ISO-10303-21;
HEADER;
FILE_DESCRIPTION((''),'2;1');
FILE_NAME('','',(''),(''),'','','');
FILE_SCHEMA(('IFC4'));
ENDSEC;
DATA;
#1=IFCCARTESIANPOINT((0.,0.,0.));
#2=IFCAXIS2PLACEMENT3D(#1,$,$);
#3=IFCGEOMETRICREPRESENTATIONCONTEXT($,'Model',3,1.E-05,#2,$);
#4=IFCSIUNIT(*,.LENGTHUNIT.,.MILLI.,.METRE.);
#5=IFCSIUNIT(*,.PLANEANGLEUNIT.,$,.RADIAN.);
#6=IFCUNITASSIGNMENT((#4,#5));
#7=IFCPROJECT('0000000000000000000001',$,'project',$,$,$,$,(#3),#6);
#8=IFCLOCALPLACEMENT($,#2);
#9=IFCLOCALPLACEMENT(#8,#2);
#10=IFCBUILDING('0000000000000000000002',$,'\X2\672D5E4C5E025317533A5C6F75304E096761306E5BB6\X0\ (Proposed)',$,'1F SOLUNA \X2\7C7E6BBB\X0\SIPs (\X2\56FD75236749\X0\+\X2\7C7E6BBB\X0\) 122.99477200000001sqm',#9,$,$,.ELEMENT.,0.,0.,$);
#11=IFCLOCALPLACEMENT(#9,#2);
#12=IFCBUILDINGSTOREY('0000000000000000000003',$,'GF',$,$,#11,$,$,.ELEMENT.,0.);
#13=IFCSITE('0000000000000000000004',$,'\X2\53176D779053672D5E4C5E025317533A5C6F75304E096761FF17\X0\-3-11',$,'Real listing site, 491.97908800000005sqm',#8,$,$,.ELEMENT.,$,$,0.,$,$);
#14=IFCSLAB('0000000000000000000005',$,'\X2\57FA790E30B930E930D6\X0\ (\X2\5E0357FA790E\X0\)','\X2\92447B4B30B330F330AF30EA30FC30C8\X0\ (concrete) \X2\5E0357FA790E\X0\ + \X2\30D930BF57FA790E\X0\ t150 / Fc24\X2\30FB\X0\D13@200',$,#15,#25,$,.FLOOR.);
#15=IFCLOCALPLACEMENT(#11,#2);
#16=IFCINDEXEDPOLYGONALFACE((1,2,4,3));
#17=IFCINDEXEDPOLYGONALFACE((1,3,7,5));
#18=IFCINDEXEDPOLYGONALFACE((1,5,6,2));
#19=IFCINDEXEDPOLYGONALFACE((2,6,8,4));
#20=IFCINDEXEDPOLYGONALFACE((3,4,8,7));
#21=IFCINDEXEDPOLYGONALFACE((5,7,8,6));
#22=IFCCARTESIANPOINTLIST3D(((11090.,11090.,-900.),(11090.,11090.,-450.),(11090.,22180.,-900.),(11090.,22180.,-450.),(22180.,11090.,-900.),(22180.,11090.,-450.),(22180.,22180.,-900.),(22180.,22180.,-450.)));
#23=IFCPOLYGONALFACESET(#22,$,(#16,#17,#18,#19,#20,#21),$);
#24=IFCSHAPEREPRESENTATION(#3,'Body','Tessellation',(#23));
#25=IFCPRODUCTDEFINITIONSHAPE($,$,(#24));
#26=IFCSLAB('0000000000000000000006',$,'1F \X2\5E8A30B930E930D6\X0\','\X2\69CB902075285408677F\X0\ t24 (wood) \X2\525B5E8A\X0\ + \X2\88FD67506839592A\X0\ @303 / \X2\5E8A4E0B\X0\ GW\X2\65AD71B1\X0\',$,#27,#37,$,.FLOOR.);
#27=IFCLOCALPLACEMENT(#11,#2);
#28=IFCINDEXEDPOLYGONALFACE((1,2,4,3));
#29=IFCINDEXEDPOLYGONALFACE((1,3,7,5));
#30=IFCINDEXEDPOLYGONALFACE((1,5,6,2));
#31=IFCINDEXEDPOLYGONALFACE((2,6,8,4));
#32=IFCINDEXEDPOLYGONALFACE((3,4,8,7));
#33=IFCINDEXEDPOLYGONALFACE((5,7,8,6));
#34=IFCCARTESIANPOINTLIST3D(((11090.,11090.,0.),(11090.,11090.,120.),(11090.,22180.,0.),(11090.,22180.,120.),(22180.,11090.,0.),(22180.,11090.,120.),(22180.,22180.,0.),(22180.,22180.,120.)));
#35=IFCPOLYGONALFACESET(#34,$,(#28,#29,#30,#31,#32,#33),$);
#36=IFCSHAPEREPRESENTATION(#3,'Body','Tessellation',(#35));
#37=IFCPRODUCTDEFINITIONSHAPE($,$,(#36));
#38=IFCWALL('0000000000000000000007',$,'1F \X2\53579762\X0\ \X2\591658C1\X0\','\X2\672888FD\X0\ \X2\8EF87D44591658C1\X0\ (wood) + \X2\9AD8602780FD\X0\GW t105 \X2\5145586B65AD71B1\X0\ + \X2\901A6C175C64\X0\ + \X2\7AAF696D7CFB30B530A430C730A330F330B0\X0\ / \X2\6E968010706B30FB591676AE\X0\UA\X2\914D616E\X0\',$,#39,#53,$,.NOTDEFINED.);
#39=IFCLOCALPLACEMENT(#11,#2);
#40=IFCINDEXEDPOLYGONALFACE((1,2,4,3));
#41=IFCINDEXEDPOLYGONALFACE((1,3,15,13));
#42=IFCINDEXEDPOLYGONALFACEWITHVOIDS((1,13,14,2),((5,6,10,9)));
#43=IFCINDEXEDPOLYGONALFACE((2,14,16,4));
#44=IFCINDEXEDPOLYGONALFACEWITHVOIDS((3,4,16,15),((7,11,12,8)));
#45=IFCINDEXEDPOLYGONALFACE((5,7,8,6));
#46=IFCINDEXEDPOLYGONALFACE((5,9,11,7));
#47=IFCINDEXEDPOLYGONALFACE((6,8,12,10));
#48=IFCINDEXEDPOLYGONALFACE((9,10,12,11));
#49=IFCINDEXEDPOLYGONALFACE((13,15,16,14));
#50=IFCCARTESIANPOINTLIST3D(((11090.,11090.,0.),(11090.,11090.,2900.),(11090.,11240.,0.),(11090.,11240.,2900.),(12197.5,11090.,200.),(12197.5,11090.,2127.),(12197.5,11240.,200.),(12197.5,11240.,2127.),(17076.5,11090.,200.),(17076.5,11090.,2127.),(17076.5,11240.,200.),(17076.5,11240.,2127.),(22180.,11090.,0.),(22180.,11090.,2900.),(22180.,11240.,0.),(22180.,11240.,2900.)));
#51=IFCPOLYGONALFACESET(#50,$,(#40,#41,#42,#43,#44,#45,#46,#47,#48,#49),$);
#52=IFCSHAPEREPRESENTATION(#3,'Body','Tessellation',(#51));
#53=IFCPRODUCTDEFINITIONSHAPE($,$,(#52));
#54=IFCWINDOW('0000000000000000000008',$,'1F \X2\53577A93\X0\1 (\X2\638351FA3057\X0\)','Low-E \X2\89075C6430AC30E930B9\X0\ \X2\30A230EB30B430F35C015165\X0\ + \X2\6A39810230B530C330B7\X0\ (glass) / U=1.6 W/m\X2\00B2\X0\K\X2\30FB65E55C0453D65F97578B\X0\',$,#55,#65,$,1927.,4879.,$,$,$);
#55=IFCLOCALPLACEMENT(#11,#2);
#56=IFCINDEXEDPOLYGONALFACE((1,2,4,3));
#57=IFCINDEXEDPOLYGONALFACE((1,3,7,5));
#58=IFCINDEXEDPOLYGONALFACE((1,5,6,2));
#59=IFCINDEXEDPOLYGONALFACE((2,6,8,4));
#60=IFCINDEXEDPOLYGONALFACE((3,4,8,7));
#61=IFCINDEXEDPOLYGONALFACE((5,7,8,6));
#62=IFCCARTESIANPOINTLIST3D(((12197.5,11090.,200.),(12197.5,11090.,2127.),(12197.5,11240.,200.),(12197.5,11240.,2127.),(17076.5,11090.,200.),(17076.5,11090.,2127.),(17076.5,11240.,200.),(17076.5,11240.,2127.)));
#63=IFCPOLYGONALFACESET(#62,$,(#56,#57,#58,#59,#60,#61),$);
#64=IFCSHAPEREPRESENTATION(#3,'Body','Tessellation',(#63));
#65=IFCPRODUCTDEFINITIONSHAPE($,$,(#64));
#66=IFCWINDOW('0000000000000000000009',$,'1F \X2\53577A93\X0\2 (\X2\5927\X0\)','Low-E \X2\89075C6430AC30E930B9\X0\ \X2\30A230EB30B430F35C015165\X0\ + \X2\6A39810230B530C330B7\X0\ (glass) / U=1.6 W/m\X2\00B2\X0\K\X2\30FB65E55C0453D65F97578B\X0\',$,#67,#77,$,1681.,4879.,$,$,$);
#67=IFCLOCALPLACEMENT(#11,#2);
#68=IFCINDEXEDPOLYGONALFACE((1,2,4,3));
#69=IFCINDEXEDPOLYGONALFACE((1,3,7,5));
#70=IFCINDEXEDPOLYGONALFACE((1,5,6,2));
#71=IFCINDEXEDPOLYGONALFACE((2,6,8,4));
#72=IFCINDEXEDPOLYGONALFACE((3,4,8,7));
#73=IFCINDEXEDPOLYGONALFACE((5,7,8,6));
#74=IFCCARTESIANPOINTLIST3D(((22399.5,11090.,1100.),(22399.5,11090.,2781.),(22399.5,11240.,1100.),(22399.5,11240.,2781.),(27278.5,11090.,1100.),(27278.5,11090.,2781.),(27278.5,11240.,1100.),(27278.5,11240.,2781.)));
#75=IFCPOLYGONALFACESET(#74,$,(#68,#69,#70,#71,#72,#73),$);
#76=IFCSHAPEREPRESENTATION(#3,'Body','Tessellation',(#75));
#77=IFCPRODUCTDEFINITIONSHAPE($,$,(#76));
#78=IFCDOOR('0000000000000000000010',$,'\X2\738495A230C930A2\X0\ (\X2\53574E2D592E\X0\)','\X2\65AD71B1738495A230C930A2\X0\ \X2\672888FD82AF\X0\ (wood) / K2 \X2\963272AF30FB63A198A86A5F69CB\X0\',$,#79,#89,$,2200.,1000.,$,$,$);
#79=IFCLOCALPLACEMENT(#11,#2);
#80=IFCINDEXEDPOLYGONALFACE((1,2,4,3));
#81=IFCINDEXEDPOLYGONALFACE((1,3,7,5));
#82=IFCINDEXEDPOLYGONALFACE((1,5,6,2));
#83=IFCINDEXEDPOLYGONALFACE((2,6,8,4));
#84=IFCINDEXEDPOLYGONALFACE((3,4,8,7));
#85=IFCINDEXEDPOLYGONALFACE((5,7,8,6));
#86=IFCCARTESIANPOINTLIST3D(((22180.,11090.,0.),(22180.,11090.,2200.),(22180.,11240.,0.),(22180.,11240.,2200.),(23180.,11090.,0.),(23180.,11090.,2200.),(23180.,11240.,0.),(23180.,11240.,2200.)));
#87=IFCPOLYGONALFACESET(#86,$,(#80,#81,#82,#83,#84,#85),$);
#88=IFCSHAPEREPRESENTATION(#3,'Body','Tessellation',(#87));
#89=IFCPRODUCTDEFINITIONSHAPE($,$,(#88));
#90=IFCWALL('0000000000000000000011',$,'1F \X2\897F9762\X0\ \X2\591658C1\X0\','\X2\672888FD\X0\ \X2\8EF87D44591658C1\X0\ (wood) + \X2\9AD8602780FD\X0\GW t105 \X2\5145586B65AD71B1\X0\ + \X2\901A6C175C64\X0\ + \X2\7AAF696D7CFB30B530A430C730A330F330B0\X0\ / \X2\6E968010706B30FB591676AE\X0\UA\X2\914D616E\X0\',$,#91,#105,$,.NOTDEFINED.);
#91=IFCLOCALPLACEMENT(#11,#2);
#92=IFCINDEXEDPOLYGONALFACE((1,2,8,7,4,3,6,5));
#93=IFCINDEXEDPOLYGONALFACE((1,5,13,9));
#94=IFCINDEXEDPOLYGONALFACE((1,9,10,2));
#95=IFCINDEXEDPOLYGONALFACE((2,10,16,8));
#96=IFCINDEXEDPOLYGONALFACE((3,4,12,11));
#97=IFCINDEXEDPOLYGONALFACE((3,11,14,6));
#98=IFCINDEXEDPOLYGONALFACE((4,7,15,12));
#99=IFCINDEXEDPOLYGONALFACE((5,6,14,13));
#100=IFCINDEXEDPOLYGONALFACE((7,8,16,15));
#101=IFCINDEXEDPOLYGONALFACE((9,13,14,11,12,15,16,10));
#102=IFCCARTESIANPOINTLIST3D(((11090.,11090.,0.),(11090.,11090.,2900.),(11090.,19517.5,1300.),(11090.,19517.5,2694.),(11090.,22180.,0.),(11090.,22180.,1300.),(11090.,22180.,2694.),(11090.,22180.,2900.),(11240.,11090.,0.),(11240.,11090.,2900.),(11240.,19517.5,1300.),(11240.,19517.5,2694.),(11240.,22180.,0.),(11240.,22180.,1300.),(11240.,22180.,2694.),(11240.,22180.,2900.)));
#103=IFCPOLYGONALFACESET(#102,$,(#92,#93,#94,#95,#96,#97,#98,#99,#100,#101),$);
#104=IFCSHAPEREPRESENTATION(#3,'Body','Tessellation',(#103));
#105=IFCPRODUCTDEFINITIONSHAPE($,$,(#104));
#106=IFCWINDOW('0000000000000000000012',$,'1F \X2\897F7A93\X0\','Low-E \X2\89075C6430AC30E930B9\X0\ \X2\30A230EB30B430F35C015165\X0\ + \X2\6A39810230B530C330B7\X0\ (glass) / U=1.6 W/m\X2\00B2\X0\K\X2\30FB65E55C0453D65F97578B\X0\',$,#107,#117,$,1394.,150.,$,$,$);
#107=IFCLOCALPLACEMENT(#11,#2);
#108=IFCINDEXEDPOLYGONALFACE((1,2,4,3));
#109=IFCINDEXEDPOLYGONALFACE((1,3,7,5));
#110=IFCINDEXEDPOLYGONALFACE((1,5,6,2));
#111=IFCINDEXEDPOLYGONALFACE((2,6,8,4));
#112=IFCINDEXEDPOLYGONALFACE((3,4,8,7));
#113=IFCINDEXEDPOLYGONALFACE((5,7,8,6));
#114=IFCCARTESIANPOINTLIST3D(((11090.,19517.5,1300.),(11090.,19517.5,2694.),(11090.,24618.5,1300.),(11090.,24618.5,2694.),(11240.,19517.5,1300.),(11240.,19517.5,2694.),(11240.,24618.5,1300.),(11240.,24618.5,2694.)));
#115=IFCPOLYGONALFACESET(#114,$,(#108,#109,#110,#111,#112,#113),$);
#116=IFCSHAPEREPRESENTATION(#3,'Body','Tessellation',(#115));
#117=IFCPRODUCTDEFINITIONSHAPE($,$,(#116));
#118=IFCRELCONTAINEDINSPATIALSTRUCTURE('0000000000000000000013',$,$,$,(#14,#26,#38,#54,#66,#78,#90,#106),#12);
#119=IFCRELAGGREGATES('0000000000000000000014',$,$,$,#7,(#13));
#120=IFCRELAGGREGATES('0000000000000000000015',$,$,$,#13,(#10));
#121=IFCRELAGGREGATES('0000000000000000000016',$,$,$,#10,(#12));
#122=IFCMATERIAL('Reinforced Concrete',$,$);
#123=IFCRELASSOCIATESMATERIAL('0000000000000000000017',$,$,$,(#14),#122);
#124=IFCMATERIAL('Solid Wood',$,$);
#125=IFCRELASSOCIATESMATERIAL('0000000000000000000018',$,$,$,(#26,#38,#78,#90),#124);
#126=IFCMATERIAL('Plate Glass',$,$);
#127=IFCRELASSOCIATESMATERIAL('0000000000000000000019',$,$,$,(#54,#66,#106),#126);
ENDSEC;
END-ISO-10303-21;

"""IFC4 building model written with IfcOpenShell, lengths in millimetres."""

from ifc_helpers import new_model, si_unit, frame, frame_2d, origin, place, context, project, spatial, rectangle, extrude, material, element, fill, save


model = new_model("IFC4")

# Units and contexts
model_context = context("Model", 3, precision=1e-05, world=origin())
ifc_project = project(units=[si_unit("LENGTHUNIT", "METRE", prefix="MILLI"), si_unit("PLANEANGLEUNIT", "RADIAN")], contexts=[model_context])

# Site, building, storey
site_placement = place(None, origin())
site = spatial("IfcSite", under=ifc_project, at=site_placement, Name="北海道札幌市北区屯田三条７-3-11", ObjectType="Real listing site, 491.97908800000005sqm", CompositionType="ELEMENT", RefElevation=0.0)
building_placement = place(site_placement, origin())
building = spatial("IfcBuilding", under=site, at=building_placement, Name="札幌市北区屯田三条の家 (Proposed)", ObjectType="1F SOLUNA 籾殻SIPs (国産杉+籾殻) 122.99477200000001sqm", CompositionType="ELEMENT", ElevationOfRefHeight=0.0, ElevationOfTerrain=0.0)
storey_placement = place(building_placement, origin())
storey = spatial("IfcBuildingStorey", under=building, at=storey_placement, Name="GF", CompositionType="ELEMENT", Elevation=0.0)

# Slabs
ifc_material_1 = material(Name="Reinforced Concrete")
slab_1_placement = place(storey_placement, frame((5545.0, 5545.0, -450.0)))
element("IfcSlab", 1, at=slab_1_placement, inside=storey, material=ifc_material_1, Name="基礎スラブ (布基礎)", Description="鉄筋コンクリート (concrete) 布基礎 + ベタ基礎 t150 / Fc24・D13@200", PredefinedType="FLOOR", context=model_context, shape_type="SweptSolid", body=[
    extrude(rectangle(XDim=11090.0, YDim=11090.0, at=frame_2d((5545.0, 5545.0))), frame((5545.0, 5545.0, -450.0)), (0.0, 0.0, 1.0), 450.0),
])
ifc_material_2 = material(Name="Solid Wood")
slab_2_placement = place(storey_placement, frame((5545.0, 5545.0, 0.0)))
element("IfcSlab", 2, at=slab_2_placement, inside=storey, material=ifc_material_2, Name="1F 床スラブ", Description="構造用合板 t24 (wood) 剛床 + 製材根太 @303 / 床下 GW断熱", PredefinedType="FLOOR", context=model_context, shape_type="SweptSolid", body=[
    extrude(rectangle(XDim=11090.0, YDim=11090.0, at=frame_2d((5545.0, 5545.0))), frame((5545.0, 5545.0, 0.0)), (0.0, 0.0, 1.0), 120.0),
])

# Wall, openings, windows, door
wall_1_placement = place(storey_placement, frame((5545.0, 5545.0, 0.0)))
wall_1 = element("IfcWall", 3, at=wall_1_placement, inside=storey, material=ifc_material_2, Name="1F 南面 外壁", Description="木製 軸組外壁 (wood) + 高性能GW t105 充填断熱 + 通気層 + 窯業系サイディング / 準耐火・外皮UA配慮", PredefinedType="NOTDEFINED", context=model_context, shape_type="SweptSolid", body=[
    extrude(rectangle(XDim=11090.0, YDim=150.0, at=frame_2d((5545.0, 75.0))), frame((5545.0, 5545.0, 0.0)), (0.0, 0.0, 1.0), 2900.0),
])
opening_1_placement = place(storey_placement, frame((6099.0, 5545.0, 100.0)))
opening_1 = element("IfcOpeningElement", 4, at=opening_1_placement, cuts=wall_1, PredefinedType="NOTDEFINED", context=model_context, shape_type="SweptSolid", body=[
    extrude(rectangle(XDim=4879.0, YDim=150.0, at=frame_2d((2439.0, 75.0))), frame((6099.0, 5545.0, 100.0)), (0.0, 0.0, 1.0), 1927.0),
])
opening_2_placement = place(storey_placement, frame((11200.0, 5545.0, 550.0)))
opening_2 = element("IfcOpeningElement", 5, at=opening_2_placement, cuts=wall_1, PredefinedType="NOTDEFINED", context=model_context, shape_type="SweptSolid", body=[
    extrude(rectangle(XDim=4879.0, YDim=150.0, at=frame_2d((2439.0, 75.0))), frame((11200.0, 5545.0, 550.0)), (0.0, 0.0, 1.0), 1681.0),
])
opening_3_placement = place(storey_placement, frame((11090.0, 5545.0, 0.0)))
opening_3 = element("IfcOpeningElement", 6, at=opening_3_placement, cuts=wall_1, PredefinedType="NOTDEFINED", context=model_context, shape_type="SweptSolid", body=[
    extrude(rectangle(XDim=1000.0, YDim=150.0, at=frame_2d((500.0, 75.0))), frame((11090.0, 5545.0, 0.0)), (0.0, 0.0, 1.0), 2200.0),
])
ifc_material_3 = material(Name="Plate Glass")
window_1_placement = place(storey_placement, frame((6099.0, 5545.0, 100.0)))
window_1 = element("IfcWindow", 7, at=window_1_placement, inside=storey, material=ifc_material_3, Name="1F 南窓1 (掃出し)", Description="Low-E 複層ガラス アルゴン封入 + 樹脂サッシ (glass) / U=1.6 W/m²K・日射取得型", OverallHeight=1927.0, OverallWidth=4879.0, context=model_context, shape_type="SweptSolid", body=[
    extrude(rectangle(XDim=4879.0, YDim=150.0, at=frame_2d((2439.0, 75.0))), frame((6099.0, 5545.0, 100.0)), (0.0, 0.0, 1.0), 1927.0),
])
fill(opening_1, window_1)
window_2_placement = place(storey_placement, frame((11200.0, 5545.0, 550.0)))
window_2 = element("IfcWindow", 8, at=window_2_placement, inside=storey, material=ifc_material_3, Name="1F 南窓2 (大)", Description="Low-E 複層ガラス アルゴン封入 + 樹脂サッシ (glass) / U=1.6 W/m²K・日射取得型", OverallHeight=1681.0, OverallWidth=4879.0, context=model_context, shape_type="SweptSolid", body=[
    extrude(rectangle(XDim=4879.0, YDim=150.0, at=frame_2d((2439.0, 75.0))), frame((11200.0, 5545.0, 550.0)), (0.0, 0.0, 1.0), 1681.0),
])
fill(opening_2, window_2)
door_placement = place(storey_placement, frame((11090.0, 5545.0, 0.0)))
door = element("IfcDoor", 9, at=door_placement, inside=storey, material=ifc_material_2, Name="玄関ドア (南中央)", Description="断熱玄関ドア 木製芯 (wood) / K2 防犯・採風機構", OverallHeight=2200.0, OverallWidth=1000.0, context=model_context, shape_type="SweptSolid", body=[
    extrude(rectangle(XDim=1000.0, YDim=150.0, at=frame_2d((500.0, 75.0))), frame((11090.0, 5545.0, 0.0)), (0.0, 0.0, 1.0), 2200.0),
])
fill(opening_3, door)

# Wall, opening, window
wall_2_placement = place(storey_placement, frame((5545.0, 5545.0, 0.0)))
wall_2 = element("IfcWall", 10, at=wall_2_placement, inside=storey, material=ifc_material_2, Name="1F 西面 外壁", Description="木製 軸組外壁 (wood) + 高性能GW t105 充填断熱 + 通気層 + 窯業系サイディング / 準耐火・外皮UA配慮", PredefinedType="NOTDEFINED", context=model_context, shape_type="SweptSolid", body=[
    extrude(rectangle(XDim=150.0, YDim=11090.0, at=frame_2d((75.0, 5545.0))), frame((5545.0, 5545.0, 0.0)), (0.0, 0.0, 1.0), 2900.0),
])
opening_4_placement = place(storey_placement, frame((5545.0, 9759.0, 650.0)))
opening_4 = element("IfcOpeningElement", 11, at=opening_4_placement, cuts=wall_2, PredefinedType="NOTDEFINED", context=model_context, shape_type="SweptSolid", body=[
    extrude(rectangle(XDim=150.0, YDim=5101.0, at=frame_2d((75.0, 2550.0))), frame((5545.0, 9759.0, 650.0)), (0.0, 0.0, 1.0), 1394.0),
])
window_3_placement = place(storey_placement, frame((5545.0, 9759.0, 650.0)))
window_3 = element("IfcWindow", 12, at=window_3_placement, inside=storey, material=ifc_material_3, Name="1F 西窓", Description="Low-E 複層ガラス アルゴン封入 + 樹脂サッシ (glass) / U=1.6 W/m²K・日射取得型", OverallHeight=1394.0, OverallWidth=150.0, context=model_context, shape_type="SweptSolid", body=[
    extrude(rectangle(XDim=150.0, YDim=5101.0, at=frame_2d((75.0, 2550.0))), frame((5545.0, 9759.0, 650.0)), (0.0, 0.0, 1.0), 1394.0),
])
fill(opening_4, window_3)

save(model, "model.ifc")
